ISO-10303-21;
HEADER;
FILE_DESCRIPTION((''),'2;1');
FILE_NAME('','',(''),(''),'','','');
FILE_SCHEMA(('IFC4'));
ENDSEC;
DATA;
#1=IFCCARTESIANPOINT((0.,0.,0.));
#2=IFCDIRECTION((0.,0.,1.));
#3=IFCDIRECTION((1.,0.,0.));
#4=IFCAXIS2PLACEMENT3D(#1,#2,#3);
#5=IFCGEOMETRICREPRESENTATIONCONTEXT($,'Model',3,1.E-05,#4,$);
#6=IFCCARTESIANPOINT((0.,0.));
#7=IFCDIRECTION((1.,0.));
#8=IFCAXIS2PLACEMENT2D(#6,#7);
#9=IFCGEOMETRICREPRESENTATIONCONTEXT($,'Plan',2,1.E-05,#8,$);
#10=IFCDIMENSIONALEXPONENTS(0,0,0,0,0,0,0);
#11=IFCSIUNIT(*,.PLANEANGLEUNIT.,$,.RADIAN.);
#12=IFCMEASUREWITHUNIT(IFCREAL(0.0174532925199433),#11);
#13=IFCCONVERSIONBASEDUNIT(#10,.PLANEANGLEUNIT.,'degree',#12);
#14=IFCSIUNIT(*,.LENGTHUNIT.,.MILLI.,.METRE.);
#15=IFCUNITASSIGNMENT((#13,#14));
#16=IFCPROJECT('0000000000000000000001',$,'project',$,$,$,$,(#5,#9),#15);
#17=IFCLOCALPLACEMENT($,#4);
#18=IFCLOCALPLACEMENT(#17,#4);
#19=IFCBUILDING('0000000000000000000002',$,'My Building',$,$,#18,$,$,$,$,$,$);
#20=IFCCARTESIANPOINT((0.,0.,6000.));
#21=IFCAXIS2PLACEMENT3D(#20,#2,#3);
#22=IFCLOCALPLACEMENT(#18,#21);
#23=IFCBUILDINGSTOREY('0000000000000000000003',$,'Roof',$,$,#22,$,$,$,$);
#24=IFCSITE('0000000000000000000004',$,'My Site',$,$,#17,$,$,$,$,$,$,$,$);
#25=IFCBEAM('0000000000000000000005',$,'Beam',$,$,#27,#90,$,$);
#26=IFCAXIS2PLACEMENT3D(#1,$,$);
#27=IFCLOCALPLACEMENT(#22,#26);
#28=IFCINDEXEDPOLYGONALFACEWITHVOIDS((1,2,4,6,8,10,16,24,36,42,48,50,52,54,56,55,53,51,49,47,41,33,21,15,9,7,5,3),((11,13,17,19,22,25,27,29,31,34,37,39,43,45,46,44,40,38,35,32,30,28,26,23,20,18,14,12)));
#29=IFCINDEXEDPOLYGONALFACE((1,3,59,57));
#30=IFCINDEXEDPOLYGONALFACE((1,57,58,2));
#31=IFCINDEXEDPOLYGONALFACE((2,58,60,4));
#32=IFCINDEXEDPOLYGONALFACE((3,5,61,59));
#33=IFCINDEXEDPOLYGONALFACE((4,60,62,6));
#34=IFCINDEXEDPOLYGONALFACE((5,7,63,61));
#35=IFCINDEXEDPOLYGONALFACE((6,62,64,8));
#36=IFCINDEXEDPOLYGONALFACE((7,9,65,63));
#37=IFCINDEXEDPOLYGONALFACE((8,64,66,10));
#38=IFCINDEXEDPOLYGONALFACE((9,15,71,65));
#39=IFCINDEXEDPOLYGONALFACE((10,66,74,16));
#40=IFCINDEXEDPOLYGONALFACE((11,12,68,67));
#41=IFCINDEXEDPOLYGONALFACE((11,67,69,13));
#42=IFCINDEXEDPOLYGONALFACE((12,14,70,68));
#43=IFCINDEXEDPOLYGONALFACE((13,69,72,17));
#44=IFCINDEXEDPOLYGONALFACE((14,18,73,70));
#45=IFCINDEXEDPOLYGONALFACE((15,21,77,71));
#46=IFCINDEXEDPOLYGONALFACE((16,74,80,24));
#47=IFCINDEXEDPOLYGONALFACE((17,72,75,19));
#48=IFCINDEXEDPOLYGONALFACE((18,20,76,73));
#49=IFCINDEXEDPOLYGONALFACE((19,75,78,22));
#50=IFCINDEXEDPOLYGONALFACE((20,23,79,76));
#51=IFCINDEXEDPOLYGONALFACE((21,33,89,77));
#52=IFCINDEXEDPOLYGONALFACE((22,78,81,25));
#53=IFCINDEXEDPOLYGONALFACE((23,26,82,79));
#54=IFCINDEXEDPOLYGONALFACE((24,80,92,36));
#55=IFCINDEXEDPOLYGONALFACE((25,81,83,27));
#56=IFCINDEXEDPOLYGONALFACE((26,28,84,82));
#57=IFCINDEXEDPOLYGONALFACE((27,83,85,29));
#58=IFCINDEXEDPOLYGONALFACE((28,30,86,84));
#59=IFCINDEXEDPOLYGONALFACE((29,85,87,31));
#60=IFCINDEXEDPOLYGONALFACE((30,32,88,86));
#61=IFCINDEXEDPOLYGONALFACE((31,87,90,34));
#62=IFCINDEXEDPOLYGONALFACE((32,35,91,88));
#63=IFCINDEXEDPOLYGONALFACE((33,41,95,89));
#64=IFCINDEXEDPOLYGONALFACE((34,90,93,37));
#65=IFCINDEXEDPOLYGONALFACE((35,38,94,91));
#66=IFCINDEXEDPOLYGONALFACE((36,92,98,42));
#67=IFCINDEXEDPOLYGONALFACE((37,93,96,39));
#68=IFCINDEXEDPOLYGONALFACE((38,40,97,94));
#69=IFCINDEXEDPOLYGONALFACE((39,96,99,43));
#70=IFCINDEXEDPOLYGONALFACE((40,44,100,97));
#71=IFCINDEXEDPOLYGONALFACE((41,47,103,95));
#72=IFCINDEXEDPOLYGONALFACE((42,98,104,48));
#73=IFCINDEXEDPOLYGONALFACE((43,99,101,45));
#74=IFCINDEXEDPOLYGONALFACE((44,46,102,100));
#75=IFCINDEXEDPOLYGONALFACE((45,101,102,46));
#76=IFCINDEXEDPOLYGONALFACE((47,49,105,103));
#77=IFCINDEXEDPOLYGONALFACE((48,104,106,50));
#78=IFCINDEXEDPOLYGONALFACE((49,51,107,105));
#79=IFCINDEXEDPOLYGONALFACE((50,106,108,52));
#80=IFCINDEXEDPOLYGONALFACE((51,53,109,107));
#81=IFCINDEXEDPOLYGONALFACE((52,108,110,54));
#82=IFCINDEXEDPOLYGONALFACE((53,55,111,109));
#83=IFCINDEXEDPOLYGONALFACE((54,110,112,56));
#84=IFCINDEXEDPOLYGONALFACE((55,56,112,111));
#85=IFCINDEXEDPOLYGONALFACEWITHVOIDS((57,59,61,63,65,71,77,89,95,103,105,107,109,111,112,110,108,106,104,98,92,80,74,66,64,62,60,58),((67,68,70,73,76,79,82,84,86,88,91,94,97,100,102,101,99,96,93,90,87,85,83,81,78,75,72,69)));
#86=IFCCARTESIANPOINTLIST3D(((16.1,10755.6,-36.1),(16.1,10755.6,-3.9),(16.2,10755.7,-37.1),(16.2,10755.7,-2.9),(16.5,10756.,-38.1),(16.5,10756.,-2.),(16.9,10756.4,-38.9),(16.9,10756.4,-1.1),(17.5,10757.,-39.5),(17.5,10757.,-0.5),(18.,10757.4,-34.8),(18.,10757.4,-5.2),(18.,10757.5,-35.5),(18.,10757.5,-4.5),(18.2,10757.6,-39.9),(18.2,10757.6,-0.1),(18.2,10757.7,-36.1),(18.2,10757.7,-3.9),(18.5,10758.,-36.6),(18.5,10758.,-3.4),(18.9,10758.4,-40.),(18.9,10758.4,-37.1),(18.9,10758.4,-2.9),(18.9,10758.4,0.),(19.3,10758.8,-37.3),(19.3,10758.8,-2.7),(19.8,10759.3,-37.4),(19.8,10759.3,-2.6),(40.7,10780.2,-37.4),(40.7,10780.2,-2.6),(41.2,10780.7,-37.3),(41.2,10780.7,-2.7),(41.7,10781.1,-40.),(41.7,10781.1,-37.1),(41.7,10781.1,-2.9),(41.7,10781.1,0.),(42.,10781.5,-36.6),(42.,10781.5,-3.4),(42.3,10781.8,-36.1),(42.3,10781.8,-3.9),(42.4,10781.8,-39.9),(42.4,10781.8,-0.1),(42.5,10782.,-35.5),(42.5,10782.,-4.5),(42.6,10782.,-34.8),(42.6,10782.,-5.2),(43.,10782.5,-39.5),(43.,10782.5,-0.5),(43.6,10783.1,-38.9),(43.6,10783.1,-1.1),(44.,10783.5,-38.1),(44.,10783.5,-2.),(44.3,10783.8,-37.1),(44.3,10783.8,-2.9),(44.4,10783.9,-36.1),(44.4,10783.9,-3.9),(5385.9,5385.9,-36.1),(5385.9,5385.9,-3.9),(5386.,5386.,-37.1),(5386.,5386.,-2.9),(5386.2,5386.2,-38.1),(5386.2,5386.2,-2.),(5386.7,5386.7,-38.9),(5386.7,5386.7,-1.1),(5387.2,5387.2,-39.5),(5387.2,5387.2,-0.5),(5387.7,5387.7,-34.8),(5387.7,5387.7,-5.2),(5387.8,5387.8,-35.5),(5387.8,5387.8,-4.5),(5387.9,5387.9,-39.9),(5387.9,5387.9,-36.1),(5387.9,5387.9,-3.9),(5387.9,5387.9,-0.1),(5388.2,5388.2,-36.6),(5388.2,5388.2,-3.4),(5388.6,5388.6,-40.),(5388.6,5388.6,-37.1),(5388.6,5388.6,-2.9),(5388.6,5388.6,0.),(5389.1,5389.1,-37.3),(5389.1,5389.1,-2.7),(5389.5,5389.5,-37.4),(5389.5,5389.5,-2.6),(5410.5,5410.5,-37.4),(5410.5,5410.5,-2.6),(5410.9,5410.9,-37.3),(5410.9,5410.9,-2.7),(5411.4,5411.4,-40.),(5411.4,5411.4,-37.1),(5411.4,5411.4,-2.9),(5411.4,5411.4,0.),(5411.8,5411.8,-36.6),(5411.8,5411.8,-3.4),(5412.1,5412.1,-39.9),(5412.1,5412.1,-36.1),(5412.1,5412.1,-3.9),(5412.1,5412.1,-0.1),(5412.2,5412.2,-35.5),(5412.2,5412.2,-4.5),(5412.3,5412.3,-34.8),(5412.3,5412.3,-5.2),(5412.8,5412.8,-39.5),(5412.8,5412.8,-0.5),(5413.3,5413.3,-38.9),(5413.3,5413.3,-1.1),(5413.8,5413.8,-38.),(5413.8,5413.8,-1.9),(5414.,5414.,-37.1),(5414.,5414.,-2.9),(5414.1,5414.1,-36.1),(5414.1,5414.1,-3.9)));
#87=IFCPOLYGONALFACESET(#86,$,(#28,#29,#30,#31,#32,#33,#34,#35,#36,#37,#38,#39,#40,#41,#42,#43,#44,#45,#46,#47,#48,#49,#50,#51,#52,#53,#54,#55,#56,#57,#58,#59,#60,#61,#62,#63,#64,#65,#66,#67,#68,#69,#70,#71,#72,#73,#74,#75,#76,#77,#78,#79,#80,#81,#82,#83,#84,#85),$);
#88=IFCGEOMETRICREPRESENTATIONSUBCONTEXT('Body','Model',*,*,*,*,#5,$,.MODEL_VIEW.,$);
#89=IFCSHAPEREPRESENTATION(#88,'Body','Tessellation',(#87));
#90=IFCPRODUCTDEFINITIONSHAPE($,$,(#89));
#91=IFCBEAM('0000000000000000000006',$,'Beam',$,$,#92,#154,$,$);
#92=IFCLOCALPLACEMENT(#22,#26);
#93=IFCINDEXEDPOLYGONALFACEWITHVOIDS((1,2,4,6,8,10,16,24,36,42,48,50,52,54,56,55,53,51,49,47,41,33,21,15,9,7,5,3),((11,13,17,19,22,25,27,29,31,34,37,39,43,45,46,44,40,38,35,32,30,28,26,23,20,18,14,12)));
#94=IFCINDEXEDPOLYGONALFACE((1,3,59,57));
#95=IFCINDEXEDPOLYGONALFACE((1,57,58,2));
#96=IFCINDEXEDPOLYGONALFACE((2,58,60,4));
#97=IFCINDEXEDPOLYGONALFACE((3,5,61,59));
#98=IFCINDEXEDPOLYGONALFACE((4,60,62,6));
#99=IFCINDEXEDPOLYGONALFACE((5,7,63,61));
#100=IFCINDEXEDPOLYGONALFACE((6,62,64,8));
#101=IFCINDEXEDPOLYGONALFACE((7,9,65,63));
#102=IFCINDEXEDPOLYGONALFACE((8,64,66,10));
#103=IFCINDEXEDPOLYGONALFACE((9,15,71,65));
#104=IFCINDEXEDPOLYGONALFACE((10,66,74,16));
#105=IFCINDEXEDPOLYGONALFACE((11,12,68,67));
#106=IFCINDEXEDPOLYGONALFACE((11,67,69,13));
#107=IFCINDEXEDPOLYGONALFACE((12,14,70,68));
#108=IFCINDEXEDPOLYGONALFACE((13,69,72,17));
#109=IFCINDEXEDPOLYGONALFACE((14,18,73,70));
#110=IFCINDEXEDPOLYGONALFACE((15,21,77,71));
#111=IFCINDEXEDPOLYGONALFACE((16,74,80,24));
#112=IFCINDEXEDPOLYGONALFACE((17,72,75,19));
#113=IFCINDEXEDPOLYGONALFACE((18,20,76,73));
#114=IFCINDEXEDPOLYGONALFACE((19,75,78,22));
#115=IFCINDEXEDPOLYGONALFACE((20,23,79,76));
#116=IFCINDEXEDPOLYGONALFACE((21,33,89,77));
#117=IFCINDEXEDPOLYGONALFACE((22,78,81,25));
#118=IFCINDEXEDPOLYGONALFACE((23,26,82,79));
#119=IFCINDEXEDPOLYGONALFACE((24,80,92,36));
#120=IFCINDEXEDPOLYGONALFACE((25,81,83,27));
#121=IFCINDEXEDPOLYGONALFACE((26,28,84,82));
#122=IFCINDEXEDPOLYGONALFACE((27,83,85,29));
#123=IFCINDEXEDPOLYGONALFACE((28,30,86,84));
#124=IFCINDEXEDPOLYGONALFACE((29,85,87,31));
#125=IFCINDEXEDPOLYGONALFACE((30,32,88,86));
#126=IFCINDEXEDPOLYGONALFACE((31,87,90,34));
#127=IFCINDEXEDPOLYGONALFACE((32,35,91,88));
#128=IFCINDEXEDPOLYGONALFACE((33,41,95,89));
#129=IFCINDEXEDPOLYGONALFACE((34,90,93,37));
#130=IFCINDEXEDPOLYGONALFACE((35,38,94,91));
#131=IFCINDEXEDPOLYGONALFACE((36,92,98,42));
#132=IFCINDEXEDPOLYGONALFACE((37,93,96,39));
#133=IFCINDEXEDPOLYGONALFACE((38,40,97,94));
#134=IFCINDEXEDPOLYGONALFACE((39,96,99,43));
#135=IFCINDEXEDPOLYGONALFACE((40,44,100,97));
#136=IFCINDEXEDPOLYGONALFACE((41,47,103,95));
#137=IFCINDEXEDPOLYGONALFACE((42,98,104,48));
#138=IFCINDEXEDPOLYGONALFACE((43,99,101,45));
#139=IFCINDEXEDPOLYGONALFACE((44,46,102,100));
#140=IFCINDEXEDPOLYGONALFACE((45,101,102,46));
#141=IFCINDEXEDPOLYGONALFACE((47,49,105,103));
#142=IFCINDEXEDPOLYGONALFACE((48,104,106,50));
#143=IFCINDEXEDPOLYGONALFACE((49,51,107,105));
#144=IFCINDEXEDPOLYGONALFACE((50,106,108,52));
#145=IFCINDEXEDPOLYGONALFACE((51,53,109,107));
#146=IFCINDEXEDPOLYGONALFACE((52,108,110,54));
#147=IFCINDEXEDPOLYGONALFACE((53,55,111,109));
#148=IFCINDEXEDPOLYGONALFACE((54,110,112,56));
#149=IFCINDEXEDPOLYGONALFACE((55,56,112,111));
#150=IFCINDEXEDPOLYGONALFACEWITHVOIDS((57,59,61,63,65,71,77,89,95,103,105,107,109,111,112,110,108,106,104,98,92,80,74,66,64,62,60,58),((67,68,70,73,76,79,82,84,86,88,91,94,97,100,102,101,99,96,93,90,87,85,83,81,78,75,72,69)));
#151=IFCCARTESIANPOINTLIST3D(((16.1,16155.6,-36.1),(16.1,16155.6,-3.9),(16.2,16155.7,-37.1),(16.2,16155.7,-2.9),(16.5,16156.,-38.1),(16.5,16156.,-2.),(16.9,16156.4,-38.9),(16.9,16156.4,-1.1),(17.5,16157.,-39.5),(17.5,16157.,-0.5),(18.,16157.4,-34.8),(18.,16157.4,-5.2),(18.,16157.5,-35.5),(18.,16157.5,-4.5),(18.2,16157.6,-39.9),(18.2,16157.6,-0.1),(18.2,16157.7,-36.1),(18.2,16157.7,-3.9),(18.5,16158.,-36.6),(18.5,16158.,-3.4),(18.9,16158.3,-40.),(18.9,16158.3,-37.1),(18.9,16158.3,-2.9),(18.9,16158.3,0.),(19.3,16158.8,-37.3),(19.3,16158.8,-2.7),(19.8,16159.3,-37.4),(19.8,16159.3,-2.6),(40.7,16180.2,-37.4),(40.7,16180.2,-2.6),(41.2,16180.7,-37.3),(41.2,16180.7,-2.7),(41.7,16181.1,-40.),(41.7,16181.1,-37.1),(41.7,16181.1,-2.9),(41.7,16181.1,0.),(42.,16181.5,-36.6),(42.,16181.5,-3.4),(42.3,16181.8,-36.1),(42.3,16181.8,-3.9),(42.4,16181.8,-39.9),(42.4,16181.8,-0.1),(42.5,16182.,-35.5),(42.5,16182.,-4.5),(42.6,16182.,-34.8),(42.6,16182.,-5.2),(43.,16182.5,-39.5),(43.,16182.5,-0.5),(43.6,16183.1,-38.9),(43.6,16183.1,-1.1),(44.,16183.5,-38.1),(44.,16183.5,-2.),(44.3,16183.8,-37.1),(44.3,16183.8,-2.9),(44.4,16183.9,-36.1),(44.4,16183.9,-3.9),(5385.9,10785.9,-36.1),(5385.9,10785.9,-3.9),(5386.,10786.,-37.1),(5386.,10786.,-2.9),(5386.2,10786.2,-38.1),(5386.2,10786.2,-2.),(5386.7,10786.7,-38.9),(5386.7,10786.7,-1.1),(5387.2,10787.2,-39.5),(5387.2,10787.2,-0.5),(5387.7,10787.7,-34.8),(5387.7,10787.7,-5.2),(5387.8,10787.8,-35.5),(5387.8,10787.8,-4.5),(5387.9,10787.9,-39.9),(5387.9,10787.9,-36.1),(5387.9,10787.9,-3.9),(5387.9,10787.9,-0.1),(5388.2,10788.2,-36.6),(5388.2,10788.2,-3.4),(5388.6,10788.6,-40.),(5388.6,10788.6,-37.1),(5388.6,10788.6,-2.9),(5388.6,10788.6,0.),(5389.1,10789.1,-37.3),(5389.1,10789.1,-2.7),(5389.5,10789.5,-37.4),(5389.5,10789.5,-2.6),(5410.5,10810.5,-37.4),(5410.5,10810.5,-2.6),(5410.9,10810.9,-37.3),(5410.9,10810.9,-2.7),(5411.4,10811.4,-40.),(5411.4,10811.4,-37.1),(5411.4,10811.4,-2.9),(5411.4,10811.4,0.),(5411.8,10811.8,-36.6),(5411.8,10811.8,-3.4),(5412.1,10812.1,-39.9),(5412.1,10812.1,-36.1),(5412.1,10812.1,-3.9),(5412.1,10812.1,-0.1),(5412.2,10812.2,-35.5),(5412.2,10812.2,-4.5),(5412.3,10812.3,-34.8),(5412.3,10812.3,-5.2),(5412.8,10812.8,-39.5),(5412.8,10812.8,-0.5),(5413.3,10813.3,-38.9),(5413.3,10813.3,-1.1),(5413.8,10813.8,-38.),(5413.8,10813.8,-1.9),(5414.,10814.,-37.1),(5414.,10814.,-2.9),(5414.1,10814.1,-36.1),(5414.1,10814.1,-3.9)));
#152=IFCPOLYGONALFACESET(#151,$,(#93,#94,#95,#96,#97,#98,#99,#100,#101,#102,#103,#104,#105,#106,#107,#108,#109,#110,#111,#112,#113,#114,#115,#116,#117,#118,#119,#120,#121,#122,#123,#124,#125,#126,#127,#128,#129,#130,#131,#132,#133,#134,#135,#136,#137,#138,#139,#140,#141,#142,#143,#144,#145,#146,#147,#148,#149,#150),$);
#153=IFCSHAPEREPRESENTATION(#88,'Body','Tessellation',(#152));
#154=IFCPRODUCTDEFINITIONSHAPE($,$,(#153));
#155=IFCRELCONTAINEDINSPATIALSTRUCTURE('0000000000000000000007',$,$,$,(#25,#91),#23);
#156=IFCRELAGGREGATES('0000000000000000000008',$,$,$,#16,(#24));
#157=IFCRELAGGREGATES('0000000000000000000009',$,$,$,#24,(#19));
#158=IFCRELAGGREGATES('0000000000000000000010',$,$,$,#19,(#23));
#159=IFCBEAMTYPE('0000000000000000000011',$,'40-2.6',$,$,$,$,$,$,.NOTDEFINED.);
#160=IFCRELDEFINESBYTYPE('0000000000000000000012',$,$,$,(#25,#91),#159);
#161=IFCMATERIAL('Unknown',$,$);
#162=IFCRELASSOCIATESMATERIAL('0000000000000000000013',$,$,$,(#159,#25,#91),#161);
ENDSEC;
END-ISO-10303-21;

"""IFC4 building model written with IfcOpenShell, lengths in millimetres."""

from ifc_helpers import new_model, entity, si_unit, converted_unit, frame, origin_with_axes, origin_2d_with_axis, place, context, subcontext, project, spatial, hollow_rectangle, extrude, material, material_profile, profile_set, profile_usage, type_object, element, save


model = new_model("IFC4")

# Units and contexts
model_context = context("Model", 3, precision=1e-05, world=origin_with_axes())
plan_context = context("Plan", 2, precision=1e-05, world=origin_2d_with_axis())
body_context = subcontext(model_context, "Body", "Model", "MODEL_VIEW")
ifc_project = project(units=[converted_unit("PLANEANGLEUNIT", "degree", entity("IfcReal", 0.0174532925199433), si_unit("PLANEANGLEUNIT", "RADIAN"), dimensions=[0, 0, 0, 0, 0, 0, 0]), si_unit("LENGTHUNIT", "METRE", prefix="MILLI")], contexts=[model_context, plan_context])

# Site, building, storey
site_placement = place(None, origin_with_axes())
site = spatial("IfcSite", under=ifc_project, at=site_placement, Name="My Site")
building_placement = place(site_placement, origin_with_axes())
building = spatial("IfcBuilding", under=site, at=building_placement, Name="My Building")
storey_placement = place(building_placement, frame((0.0, 0.0, 6000.0), z_axis=(0.0, 0.0, 1.0), x_axis=(1.0, 0.0, 0.0)))
storey = spatial("IfcBuildingStorey", under=building, at=storey_placement, Name="Roof")

# Beams
ifc_material = material(Name="Unknown")
ifc_material_profile_1 = material_profile(ifc_material, hollow_rectangle(XDim=40.0, YDim=40.0, WallThickness=2.6, InnerFilletRadius=2.6, OuterFilletRadius=3.9))
ifc_profile_set_1 = profile_set([ifc_material_profile_1])
beam_type_1 = type_object("IfcBeamType", Name="40-2.6", PredefinedType="NOTDEFINED", material=ifc_profile_set_1)
ifc_profile_usage_1 = profile_usage(ifc_profile_set_1, cardinal=8)
beam_1_placement = place(storey_placement, frame((5400.0, 5400.0, 0.0), z_axis=(-0.707107, 0.707107, 0.0), x_axis=(-0.707107, -0.707107, 0.0)))
element("IfcBeam", 1, at=beam_1_placement, inside=storey, type_object=beam_type_1, material=ifc_profile_usage_1, Name="Beam", context=body_context, shape_type="SweptSolid", body=[
    extrude(hollow_rectangle(XDim=40.0, YDim=40.0, WallThickness=2.6, InnerFilletRadius=2.6, OuterFilletRadius=3.9), frame((0.0, -20.0, 0.0), z_axis=(0.0, 0.0, 1.0), x_axis=(1.0, 0.0, 0.0)), (0.0, 0.0, 1.0), 7594.0),
])
ifc_profile_usage_2 = profile_usage(ifc_profile_set_1, cardinal=8)
beam_2_placement = place(storey_placement, frame((5400.0, 10800.0, 0.0), z_axis=(-0.707107, 0.707107, 0.0), x_axis=(-0.707107, -0.707107, 0.0)))
element("IfcBeam", 2, at=beam_2_placement, inside=storey, type_object=beam_type_1, material=ifc_profile_usage_2, Name="Beam", context=body_context, shape_type="SweptSolid", body=[
    extrude(hollow_rectangle(XDim=40.0, YDim=40.0, WallThickness=2.6, InnerFilletRadius=2.6, OuterFilletRadius=3.9), frame((0.0, -20.0, 0.0), z_axis=(0.0, 0.0, 1.0), x_axis=(1.0, 0.0, 0.0)), (0.0, 0.0, 1.0), 7594.0),
])

save(model, "model.ifc")
